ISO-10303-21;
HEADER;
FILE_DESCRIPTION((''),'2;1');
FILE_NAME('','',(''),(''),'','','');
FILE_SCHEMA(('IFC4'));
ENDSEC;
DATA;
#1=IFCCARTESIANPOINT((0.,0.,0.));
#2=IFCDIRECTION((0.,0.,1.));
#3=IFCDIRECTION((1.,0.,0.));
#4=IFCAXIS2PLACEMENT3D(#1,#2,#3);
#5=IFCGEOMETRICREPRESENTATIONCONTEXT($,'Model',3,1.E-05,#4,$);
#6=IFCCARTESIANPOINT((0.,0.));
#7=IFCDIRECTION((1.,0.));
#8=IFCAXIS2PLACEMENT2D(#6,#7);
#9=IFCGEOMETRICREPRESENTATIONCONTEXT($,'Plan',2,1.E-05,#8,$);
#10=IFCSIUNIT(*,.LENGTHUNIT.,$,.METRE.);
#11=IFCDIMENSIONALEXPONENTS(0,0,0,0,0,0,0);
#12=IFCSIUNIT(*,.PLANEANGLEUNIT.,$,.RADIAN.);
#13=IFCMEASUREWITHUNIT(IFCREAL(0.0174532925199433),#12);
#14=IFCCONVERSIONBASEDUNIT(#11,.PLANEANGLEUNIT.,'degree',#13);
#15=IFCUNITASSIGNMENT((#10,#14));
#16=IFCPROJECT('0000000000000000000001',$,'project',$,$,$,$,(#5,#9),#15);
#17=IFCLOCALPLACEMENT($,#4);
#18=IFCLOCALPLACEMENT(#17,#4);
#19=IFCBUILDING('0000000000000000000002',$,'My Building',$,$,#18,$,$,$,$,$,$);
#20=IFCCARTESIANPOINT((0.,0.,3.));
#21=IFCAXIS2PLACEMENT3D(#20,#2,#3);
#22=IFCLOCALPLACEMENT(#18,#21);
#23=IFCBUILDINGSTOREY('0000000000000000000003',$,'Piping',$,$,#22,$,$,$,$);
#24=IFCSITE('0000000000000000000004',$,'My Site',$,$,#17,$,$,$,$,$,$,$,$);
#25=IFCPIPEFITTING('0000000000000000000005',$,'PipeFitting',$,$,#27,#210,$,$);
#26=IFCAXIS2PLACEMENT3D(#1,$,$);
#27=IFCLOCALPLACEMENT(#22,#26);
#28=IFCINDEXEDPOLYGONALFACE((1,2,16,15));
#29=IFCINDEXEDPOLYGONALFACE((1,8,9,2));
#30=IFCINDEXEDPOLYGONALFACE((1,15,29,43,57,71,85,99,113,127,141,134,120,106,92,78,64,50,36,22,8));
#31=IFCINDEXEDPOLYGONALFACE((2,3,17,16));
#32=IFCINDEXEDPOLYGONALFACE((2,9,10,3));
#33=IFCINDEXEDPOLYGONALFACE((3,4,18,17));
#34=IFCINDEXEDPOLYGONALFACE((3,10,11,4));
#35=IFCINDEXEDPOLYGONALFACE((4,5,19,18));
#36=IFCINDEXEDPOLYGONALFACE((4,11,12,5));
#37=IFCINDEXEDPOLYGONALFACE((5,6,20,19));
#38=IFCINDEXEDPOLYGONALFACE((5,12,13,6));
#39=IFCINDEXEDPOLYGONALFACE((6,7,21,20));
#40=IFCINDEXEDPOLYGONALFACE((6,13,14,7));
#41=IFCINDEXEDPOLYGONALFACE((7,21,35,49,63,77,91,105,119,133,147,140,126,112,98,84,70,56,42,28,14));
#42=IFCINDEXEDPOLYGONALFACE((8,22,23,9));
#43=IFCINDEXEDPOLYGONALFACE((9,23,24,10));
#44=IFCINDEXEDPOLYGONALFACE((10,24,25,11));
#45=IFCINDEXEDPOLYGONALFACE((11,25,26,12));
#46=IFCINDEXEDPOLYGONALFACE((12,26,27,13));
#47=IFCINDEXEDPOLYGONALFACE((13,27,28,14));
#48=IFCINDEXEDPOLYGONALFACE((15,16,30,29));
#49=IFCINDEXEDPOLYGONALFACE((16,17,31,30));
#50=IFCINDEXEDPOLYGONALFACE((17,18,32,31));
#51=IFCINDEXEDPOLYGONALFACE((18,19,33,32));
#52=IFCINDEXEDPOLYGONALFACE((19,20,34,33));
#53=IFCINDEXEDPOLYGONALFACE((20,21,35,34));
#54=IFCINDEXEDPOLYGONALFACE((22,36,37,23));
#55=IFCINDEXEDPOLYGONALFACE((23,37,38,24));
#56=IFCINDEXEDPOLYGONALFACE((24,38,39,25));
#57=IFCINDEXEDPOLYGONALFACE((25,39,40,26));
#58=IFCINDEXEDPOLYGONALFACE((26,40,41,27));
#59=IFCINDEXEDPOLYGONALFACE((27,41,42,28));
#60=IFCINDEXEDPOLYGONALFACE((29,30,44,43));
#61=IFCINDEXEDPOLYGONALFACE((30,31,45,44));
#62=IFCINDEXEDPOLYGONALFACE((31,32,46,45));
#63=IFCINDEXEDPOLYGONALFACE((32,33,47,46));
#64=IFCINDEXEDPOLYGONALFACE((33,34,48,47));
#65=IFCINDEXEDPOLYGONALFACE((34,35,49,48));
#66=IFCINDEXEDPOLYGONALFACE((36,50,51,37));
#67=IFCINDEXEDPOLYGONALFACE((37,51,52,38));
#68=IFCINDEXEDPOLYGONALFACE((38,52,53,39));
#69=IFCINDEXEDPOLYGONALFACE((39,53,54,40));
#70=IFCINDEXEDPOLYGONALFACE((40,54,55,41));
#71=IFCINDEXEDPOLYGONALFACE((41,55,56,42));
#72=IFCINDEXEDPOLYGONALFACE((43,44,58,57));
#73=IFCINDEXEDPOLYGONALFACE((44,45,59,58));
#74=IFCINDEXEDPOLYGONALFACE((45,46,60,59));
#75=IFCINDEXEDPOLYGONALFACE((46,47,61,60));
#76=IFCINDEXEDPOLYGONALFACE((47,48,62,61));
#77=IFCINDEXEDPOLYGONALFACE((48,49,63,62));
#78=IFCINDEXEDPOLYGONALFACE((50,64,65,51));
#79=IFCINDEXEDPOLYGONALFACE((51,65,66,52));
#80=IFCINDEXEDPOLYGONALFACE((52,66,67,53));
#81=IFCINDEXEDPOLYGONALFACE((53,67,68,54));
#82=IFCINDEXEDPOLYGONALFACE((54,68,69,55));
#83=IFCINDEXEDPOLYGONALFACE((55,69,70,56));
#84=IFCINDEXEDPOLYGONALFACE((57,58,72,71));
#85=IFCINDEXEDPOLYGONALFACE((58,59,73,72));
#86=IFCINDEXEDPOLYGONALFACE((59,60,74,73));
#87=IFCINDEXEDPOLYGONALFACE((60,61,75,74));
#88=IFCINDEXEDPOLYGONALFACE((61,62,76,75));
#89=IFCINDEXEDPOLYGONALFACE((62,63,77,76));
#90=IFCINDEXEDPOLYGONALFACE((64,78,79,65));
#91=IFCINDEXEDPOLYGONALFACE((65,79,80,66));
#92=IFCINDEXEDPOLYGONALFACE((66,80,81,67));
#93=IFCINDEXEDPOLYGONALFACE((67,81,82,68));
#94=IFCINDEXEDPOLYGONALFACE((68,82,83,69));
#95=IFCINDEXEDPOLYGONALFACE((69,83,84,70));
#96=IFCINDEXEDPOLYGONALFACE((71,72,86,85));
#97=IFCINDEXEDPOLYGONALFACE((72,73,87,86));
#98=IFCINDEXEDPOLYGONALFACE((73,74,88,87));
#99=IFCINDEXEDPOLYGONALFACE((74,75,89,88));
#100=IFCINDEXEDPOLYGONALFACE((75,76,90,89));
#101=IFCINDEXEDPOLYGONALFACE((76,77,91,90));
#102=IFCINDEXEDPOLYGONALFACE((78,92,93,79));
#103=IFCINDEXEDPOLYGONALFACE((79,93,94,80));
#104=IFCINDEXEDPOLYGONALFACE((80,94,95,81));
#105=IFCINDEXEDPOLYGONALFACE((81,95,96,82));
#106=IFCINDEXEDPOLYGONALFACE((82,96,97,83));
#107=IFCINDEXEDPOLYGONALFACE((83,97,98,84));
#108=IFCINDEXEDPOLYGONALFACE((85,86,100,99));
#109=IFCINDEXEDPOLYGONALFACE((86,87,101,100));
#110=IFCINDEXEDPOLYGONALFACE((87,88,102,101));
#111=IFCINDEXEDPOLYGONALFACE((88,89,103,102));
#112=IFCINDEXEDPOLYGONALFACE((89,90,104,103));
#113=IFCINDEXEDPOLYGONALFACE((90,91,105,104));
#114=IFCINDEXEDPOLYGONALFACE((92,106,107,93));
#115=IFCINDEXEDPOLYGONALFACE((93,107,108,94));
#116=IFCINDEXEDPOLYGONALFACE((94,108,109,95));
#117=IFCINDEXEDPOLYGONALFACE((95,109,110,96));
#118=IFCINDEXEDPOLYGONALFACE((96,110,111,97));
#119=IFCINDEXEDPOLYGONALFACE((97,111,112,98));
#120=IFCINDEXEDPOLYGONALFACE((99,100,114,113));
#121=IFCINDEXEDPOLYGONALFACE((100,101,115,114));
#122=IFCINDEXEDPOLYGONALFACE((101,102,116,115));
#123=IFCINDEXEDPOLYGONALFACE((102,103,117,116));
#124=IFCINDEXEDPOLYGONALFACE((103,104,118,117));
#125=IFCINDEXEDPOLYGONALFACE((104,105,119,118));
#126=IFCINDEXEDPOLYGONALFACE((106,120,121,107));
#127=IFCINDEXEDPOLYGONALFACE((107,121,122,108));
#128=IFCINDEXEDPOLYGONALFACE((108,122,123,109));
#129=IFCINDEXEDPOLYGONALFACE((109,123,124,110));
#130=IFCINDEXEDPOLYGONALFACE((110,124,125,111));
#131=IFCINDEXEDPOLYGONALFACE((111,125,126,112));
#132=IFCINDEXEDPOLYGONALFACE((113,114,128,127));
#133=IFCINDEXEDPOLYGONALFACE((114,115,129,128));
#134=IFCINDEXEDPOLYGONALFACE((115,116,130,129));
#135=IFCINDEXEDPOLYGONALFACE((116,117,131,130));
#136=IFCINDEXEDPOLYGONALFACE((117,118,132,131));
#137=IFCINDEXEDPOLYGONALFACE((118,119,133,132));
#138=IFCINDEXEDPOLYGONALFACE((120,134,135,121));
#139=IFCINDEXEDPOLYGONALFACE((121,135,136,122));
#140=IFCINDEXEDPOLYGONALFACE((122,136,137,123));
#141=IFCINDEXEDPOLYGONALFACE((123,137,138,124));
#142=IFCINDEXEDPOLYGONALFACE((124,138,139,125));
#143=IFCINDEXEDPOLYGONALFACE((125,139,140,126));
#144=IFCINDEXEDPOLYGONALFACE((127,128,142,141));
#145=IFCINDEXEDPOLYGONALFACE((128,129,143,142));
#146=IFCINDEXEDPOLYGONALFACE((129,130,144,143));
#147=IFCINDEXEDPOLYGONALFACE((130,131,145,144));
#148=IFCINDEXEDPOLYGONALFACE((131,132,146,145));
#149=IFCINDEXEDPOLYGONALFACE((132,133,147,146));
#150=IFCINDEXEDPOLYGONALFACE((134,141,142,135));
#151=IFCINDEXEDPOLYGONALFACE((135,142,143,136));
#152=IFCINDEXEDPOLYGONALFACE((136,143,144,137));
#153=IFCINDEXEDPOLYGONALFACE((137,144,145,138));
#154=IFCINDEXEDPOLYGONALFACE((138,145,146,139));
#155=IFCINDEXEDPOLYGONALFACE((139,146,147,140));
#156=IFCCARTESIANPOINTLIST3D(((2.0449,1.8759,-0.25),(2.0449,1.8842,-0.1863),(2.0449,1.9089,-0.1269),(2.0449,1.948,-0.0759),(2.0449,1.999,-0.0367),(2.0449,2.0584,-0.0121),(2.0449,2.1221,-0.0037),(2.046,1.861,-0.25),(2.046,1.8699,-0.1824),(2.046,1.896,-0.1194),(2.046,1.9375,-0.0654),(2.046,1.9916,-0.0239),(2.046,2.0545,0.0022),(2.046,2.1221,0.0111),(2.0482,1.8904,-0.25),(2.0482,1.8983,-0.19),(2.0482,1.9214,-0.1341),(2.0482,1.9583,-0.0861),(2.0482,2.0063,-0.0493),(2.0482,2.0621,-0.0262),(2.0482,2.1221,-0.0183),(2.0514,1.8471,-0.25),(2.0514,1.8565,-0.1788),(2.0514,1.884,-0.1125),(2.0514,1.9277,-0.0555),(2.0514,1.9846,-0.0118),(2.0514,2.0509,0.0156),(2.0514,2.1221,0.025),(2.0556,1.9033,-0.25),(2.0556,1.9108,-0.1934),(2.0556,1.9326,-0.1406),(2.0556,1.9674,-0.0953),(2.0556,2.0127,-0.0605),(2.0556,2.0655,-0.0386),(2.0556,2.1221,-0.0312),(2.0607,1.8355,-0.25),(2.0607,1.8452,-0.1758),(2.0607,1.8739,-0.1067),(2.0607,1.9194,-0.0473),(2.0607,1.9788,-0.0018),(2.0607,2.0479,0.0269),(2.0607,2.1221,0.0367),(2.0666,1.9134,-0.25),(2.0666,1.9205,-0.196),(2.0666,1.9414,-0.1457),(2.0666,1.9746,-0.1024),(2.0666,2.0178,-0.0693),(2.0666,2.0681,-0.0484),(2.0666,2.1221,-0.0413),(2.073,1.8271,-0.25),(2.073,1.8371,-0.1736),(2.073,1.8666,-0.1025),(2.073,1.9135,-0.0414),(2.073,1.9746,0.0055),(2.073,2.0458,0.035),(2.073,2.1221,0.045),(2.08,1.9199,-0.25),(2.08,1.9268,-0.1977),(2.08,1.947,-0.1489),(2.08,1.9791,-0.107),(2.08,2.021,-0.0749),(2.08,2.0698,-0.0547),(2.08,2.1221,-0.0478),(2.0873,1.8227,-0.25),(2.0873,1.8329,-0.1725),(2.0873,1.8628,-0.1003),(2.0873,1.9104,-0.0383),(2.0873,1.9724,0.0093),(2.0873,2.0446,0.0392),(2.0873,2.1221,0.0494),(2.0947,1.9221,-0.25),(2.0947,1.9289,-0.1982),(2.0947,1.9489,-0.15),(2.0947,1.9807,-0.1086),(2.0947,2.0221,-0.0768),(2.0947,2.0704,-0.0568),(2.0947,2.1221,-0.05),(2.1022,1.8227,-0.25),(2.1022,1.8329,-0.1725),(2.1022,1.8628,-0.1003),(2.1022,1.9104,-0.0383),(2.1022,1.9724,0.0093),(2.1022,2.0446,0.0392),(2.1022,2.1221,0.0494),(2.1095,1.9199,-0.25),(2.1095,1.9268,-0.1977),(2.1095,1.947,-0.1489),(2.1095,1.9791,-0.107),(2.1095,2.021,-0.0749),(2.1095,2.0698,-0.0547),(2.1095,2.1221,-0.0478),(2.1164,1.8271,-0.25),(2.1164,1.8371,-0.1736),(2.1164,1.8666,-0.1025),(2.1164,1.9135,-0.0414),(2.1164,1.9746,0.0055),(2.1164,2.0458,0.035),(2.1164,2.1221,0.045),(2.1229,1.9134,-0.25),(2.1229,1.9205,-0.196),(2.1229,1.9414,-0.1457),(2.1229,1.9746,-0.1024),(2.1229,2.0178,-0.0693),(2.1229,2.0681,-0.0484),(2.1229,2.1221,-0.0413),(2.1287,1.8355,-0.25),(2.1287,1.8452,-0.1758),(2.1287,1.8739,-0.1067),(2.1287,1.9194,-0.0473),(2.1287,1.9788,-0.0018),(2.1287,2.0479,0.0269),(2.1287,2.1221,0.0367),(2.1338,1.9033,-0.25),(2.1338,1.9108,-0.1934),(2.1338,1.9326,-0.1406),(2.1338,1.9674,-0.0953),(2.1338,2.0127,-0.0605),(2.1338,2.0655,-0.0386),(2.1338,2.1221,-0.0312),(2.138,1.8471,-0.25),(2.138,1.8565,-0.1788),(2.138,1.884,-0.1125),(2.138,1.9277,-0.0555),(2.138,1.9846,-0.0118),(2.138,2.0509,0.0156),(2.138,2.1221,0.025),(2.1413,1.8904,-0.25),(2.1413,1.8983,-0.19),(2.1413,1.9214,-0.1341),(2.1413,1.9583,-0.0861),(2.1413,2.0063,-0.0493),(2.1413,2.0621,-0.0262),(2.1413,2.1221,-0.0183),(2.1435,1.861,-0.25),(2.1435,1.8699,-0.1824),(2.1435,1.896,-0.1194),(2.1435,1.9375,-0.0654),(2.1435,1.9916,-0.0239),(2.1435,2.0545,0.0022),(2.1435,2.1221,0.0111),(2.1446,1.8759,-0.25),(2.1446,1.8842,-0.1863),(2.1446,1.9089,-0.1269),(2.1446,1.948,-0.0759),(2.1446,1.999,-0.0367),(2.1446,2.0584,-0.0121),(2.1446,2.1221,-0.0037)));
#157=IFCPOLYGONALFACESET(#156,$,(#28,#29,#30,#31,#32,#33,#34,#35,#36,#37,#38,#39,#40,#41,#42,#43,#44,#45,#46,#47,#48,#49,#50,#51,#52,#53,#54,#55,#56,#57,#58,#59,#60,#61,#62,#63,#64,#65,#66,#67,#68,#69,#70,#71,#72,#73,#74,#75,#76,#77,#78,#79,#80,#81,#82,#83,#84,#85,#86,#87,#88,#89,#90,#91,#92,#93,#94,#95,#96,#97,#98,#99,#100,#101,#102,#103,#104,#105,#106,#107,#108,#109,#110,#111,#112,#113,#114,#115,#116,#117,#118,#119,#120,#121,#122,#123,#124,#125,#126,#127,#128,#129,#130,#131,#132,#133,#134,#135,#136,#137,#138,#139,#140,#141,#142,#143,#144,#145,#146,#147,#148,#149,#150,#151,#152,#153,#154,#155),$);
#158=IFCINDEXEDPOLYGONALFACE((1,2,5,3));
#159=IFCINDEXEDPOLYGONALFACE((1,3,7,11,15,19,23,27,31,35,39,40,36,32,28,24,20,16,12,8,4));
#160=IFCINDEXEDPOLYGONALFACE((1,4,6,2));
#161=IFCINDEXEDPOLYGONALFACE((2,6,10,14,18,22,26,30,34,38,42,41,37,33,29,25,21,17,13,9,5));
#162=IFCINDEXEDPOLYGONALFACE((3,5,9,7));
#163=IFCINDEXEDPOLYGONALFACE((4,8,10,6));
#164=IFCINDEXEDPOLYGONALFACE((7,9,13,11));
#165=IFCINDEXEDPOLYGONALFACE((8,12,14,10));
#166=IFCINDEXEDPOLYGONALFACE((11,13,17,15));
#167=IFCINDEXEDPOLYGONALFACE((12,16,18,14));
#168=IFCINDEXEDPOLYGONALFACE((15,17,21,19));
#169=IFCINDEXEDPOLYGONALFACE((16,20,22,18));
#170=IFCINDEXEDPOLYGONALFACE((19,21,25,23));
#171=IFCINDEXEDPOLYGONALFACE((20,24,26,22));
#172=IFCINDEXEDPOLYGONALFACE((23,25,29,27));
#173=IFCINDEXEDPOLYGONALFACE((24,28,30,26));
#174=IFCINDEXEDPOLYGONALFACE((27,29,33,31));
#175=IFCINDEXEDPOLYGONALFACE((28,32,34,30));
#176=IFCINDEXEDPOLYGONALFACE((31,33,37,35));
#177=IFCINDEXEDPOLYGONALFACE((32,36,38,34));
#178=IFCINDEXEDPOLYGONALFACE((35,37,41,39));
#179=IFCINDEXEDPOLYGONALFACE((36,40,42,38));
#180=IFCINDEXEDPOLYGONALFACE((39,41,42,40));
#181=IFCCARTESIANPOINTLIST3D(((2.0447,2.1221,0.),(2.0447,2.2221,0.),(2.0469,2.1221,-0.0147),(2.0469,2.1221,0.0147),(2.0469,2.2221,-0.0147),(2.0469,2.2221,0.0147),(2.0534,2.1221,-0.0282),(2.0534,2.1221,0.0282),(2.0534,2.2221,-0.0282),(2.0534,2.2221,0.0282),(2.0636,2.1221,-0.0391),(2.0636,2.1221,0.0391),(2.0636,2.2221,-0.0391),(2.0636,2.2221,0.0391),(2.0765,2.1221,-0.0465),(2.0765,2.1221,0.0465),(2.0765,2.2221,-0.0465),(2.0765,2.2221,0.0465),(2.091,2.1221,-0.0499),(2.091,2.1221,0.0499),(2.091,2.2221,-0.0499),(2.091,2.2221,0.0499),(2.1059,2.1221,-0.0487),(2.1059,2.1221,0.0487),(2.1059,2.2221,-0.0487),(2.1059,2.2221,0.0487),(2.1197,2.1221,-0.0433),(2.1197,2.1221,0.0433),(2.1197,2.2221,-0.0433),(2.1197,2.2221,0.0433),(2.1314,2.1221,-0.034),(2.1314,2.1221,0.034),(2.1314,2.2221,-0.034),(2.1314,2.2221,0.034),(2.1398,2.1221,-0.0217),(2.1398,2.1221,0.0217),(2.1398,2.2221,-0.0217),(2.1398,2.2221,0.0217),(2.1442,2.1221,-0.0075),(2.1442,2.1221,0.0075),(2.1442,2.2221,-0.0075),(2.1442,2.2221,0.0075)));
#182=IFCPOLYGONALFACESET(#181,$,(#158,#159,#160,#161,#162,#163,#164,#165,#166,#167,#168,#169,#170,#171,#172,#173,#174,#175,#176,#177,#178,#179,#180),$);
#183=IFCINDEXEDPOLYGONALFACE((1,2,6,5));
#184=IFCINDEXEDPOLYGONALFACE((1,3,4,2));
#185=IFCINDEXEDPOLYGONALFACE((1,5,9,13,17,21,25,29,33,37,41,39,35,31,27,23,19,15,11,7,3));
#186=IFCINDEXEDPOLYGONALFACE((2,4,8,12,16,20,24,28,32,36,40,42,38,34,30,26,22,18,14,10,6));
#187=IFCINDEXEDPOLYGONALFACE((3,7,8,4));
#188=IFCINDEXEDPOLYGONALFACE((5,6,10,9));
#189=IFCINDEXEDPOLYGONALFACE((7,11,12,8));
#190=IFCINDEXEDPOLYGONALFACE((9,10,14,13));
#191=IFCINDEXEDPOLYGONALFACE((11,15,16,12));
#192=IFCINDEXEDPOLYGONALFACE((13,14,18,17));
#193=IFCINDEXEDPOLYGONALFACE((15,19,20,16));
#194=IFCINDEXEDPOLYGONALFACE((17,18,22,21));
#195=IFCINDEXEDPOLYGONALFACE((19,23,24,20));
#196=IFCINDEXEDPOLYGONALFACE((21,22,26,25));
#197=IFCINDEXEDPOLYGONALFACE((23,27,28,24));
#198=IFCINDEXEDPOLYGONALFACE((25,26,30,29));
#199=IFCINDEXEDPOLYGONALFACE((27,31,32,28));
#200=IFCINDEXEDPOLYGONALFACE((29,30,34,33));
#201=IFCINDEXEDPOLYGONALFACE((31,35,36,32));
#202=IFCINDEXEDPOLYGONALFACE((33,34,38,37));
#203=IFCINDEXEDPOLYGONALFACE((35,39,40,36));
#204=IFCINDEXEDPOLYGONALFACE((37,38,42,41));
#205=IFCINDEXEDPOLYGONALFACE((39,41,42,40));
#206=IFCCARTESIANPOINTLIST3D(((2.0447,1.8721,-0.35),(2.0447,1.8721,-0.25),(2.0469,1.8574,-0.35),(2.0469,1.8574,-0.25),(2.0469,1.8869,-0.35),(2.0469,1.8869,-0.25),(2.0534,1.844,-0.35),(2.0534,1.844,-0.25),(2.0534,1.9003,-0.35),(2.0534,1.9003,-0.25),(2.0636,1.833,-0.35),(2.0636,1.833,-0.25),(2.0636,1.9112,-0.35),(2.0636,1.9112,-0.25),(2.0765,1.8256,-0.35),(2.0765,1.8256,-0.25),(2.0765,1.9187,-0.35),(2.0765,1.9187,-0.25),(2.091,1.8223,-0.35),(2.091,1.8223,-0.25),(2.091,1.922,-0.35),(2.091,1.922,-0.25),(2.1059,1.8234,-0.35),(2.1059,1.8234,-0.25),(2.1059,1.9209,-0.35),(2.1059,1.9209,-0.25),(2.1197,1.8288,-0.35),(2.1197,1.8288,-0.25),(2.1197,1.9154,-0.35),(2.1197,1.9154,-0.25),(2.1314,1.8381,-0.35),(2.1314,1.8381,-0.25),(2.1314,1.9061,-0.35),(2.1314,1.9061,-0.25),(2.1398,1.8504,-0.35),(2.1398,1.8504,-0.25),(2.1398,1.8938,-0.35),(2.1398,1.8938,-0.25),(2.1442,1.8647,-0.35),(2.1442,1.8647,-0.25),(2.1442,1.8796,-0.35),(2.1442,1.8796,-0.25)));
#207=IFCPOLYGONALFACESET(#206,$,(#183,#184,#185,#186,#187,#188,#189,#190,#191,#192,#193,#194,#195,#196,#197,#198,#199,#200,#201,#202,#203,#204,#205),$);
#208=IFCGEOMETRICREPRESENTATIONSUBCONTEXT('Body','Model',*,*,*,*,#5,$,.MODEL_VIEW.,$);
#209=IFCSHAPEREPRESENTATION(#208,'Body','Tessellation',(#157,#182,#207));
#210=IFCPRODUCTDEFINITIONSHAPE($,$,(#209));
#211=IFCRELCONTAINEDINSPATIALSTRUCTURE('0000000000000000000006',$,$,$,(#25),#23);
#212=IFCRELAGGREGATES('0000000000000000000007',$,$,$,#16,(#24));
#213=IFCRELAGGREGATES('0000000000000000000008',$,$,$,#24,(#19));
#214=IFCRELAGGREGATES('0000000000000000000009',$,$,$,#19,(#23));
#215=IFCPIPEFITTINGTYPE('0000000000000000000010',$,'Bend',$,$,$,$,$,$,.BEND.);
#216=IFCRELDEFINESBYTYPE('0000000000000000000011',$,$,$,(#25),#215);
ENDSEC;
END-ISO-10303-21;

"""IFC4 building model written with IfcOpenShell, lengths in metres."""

from ifc_helpers import new_model, entity, si_unit, converted_unit, frame, origin_with_axes, origin_2d_with_axis, place, context, subcontext, project, spatial, circle, extrude, source, transform, mapped, type_object, type_shapes, element, save


model = new_model("IFC4")

# Units and contexts
model_context = context("Model", 3, precision=1e-05, world=origin_with_axes())
plan_context = context("Plan", 2, precision=1e-05, world=origin_2d_with_axis())
body_context = subcontext(model_context, "Body", "Model", "MODEL_VIEW")
ifc_project = project(units=[si_unit("LENGTHUNIT", "METRE"), converted_unit("PLANEANGLEUNIT", "degree", entity("IfcReal", 0.0174532925199433), si_unit("PLANEANGLEUNIT", "RADIAN"), dimensions=[0, 0, 0, 0, 0, 0, 0])], contexts=[model_context, plan_context])

# Site, building, storey
site_placement = place(None, origin_with_axes())
site = spatial("IfcSite", under=ifc_project, at=site_placement, Name="My Site")
building_placement = place(site_placement, origin_with_axes())
building = spatial("IfcBuilding", under=site, at=building_placement, Name="My Building")
storey_placement = place(building_placement, frame((0.0, 0.0, 3.0), z_axis=(0.0, 0.0, 1.0), x_axis=(1.0, 0.0, 0.0)))
storey = spatial("IfcBuildingStorey", under=building, at=storey_placement, Name="Piping")

# Pipe fitting
pipe_fitting_type_1 = type_object("IfcPipeFittingType", Name="Bend", PredefinedType="BEND")
shared_shape = source(origin_with_axes(), body_context, "Body", "SolidModel", [
    entity("IfcSweptDiskSolid", entity("IfcIndexedPolyCurve", entity("IfcCartesianPointList3D", [[0.0, 0.0, -0.1], [0.0, -0.0732, -0.2768], [0.0, -0.25, -0.35]]), [entity("IfcArcIndex", [1, 2, 3])]), 0.05),
    extrude(circle(Radius=0.05), origin_with_axes(), (0.0, 0.0, -1.0), 0.1),
    extrude(circle(Radius=0.05), frame((0.0, -0.25, -0.35), z_axis=(0.0, -1.0, 0.0), x_axis=(1.0, 0.0, 0.0)), (0.0, 0.0, 1.0), 0.1),
])
type_shapes(pipe_fitting_type_1, [shared_shape])
pipe_fitting_1_placement = place(storey_placement, frame((2.0947, 2.2221, 0.0), z_axis=(0.0, 1.0, 0.0), x_axis=(-1.0, 0.0, 0.0)))
element("IfcPipeFitting", 1, at=pipe_fitting_1_placement, inside=storey, type_object=pipe_fitting_type_1, Name="PipeFitting", context=body_context, shape_type="MappedRepresentation", body=[
    mapped(shared_shape, transform((0.0, 0.0, 0.0), x_axis=(1.0, 0.0, 0.0), y_axis=(0.0, 1.0, 0.0), z_axis=(0.0, 0.0, 1.0), scale=1.0)),
])

save(model, "model.ifc")
